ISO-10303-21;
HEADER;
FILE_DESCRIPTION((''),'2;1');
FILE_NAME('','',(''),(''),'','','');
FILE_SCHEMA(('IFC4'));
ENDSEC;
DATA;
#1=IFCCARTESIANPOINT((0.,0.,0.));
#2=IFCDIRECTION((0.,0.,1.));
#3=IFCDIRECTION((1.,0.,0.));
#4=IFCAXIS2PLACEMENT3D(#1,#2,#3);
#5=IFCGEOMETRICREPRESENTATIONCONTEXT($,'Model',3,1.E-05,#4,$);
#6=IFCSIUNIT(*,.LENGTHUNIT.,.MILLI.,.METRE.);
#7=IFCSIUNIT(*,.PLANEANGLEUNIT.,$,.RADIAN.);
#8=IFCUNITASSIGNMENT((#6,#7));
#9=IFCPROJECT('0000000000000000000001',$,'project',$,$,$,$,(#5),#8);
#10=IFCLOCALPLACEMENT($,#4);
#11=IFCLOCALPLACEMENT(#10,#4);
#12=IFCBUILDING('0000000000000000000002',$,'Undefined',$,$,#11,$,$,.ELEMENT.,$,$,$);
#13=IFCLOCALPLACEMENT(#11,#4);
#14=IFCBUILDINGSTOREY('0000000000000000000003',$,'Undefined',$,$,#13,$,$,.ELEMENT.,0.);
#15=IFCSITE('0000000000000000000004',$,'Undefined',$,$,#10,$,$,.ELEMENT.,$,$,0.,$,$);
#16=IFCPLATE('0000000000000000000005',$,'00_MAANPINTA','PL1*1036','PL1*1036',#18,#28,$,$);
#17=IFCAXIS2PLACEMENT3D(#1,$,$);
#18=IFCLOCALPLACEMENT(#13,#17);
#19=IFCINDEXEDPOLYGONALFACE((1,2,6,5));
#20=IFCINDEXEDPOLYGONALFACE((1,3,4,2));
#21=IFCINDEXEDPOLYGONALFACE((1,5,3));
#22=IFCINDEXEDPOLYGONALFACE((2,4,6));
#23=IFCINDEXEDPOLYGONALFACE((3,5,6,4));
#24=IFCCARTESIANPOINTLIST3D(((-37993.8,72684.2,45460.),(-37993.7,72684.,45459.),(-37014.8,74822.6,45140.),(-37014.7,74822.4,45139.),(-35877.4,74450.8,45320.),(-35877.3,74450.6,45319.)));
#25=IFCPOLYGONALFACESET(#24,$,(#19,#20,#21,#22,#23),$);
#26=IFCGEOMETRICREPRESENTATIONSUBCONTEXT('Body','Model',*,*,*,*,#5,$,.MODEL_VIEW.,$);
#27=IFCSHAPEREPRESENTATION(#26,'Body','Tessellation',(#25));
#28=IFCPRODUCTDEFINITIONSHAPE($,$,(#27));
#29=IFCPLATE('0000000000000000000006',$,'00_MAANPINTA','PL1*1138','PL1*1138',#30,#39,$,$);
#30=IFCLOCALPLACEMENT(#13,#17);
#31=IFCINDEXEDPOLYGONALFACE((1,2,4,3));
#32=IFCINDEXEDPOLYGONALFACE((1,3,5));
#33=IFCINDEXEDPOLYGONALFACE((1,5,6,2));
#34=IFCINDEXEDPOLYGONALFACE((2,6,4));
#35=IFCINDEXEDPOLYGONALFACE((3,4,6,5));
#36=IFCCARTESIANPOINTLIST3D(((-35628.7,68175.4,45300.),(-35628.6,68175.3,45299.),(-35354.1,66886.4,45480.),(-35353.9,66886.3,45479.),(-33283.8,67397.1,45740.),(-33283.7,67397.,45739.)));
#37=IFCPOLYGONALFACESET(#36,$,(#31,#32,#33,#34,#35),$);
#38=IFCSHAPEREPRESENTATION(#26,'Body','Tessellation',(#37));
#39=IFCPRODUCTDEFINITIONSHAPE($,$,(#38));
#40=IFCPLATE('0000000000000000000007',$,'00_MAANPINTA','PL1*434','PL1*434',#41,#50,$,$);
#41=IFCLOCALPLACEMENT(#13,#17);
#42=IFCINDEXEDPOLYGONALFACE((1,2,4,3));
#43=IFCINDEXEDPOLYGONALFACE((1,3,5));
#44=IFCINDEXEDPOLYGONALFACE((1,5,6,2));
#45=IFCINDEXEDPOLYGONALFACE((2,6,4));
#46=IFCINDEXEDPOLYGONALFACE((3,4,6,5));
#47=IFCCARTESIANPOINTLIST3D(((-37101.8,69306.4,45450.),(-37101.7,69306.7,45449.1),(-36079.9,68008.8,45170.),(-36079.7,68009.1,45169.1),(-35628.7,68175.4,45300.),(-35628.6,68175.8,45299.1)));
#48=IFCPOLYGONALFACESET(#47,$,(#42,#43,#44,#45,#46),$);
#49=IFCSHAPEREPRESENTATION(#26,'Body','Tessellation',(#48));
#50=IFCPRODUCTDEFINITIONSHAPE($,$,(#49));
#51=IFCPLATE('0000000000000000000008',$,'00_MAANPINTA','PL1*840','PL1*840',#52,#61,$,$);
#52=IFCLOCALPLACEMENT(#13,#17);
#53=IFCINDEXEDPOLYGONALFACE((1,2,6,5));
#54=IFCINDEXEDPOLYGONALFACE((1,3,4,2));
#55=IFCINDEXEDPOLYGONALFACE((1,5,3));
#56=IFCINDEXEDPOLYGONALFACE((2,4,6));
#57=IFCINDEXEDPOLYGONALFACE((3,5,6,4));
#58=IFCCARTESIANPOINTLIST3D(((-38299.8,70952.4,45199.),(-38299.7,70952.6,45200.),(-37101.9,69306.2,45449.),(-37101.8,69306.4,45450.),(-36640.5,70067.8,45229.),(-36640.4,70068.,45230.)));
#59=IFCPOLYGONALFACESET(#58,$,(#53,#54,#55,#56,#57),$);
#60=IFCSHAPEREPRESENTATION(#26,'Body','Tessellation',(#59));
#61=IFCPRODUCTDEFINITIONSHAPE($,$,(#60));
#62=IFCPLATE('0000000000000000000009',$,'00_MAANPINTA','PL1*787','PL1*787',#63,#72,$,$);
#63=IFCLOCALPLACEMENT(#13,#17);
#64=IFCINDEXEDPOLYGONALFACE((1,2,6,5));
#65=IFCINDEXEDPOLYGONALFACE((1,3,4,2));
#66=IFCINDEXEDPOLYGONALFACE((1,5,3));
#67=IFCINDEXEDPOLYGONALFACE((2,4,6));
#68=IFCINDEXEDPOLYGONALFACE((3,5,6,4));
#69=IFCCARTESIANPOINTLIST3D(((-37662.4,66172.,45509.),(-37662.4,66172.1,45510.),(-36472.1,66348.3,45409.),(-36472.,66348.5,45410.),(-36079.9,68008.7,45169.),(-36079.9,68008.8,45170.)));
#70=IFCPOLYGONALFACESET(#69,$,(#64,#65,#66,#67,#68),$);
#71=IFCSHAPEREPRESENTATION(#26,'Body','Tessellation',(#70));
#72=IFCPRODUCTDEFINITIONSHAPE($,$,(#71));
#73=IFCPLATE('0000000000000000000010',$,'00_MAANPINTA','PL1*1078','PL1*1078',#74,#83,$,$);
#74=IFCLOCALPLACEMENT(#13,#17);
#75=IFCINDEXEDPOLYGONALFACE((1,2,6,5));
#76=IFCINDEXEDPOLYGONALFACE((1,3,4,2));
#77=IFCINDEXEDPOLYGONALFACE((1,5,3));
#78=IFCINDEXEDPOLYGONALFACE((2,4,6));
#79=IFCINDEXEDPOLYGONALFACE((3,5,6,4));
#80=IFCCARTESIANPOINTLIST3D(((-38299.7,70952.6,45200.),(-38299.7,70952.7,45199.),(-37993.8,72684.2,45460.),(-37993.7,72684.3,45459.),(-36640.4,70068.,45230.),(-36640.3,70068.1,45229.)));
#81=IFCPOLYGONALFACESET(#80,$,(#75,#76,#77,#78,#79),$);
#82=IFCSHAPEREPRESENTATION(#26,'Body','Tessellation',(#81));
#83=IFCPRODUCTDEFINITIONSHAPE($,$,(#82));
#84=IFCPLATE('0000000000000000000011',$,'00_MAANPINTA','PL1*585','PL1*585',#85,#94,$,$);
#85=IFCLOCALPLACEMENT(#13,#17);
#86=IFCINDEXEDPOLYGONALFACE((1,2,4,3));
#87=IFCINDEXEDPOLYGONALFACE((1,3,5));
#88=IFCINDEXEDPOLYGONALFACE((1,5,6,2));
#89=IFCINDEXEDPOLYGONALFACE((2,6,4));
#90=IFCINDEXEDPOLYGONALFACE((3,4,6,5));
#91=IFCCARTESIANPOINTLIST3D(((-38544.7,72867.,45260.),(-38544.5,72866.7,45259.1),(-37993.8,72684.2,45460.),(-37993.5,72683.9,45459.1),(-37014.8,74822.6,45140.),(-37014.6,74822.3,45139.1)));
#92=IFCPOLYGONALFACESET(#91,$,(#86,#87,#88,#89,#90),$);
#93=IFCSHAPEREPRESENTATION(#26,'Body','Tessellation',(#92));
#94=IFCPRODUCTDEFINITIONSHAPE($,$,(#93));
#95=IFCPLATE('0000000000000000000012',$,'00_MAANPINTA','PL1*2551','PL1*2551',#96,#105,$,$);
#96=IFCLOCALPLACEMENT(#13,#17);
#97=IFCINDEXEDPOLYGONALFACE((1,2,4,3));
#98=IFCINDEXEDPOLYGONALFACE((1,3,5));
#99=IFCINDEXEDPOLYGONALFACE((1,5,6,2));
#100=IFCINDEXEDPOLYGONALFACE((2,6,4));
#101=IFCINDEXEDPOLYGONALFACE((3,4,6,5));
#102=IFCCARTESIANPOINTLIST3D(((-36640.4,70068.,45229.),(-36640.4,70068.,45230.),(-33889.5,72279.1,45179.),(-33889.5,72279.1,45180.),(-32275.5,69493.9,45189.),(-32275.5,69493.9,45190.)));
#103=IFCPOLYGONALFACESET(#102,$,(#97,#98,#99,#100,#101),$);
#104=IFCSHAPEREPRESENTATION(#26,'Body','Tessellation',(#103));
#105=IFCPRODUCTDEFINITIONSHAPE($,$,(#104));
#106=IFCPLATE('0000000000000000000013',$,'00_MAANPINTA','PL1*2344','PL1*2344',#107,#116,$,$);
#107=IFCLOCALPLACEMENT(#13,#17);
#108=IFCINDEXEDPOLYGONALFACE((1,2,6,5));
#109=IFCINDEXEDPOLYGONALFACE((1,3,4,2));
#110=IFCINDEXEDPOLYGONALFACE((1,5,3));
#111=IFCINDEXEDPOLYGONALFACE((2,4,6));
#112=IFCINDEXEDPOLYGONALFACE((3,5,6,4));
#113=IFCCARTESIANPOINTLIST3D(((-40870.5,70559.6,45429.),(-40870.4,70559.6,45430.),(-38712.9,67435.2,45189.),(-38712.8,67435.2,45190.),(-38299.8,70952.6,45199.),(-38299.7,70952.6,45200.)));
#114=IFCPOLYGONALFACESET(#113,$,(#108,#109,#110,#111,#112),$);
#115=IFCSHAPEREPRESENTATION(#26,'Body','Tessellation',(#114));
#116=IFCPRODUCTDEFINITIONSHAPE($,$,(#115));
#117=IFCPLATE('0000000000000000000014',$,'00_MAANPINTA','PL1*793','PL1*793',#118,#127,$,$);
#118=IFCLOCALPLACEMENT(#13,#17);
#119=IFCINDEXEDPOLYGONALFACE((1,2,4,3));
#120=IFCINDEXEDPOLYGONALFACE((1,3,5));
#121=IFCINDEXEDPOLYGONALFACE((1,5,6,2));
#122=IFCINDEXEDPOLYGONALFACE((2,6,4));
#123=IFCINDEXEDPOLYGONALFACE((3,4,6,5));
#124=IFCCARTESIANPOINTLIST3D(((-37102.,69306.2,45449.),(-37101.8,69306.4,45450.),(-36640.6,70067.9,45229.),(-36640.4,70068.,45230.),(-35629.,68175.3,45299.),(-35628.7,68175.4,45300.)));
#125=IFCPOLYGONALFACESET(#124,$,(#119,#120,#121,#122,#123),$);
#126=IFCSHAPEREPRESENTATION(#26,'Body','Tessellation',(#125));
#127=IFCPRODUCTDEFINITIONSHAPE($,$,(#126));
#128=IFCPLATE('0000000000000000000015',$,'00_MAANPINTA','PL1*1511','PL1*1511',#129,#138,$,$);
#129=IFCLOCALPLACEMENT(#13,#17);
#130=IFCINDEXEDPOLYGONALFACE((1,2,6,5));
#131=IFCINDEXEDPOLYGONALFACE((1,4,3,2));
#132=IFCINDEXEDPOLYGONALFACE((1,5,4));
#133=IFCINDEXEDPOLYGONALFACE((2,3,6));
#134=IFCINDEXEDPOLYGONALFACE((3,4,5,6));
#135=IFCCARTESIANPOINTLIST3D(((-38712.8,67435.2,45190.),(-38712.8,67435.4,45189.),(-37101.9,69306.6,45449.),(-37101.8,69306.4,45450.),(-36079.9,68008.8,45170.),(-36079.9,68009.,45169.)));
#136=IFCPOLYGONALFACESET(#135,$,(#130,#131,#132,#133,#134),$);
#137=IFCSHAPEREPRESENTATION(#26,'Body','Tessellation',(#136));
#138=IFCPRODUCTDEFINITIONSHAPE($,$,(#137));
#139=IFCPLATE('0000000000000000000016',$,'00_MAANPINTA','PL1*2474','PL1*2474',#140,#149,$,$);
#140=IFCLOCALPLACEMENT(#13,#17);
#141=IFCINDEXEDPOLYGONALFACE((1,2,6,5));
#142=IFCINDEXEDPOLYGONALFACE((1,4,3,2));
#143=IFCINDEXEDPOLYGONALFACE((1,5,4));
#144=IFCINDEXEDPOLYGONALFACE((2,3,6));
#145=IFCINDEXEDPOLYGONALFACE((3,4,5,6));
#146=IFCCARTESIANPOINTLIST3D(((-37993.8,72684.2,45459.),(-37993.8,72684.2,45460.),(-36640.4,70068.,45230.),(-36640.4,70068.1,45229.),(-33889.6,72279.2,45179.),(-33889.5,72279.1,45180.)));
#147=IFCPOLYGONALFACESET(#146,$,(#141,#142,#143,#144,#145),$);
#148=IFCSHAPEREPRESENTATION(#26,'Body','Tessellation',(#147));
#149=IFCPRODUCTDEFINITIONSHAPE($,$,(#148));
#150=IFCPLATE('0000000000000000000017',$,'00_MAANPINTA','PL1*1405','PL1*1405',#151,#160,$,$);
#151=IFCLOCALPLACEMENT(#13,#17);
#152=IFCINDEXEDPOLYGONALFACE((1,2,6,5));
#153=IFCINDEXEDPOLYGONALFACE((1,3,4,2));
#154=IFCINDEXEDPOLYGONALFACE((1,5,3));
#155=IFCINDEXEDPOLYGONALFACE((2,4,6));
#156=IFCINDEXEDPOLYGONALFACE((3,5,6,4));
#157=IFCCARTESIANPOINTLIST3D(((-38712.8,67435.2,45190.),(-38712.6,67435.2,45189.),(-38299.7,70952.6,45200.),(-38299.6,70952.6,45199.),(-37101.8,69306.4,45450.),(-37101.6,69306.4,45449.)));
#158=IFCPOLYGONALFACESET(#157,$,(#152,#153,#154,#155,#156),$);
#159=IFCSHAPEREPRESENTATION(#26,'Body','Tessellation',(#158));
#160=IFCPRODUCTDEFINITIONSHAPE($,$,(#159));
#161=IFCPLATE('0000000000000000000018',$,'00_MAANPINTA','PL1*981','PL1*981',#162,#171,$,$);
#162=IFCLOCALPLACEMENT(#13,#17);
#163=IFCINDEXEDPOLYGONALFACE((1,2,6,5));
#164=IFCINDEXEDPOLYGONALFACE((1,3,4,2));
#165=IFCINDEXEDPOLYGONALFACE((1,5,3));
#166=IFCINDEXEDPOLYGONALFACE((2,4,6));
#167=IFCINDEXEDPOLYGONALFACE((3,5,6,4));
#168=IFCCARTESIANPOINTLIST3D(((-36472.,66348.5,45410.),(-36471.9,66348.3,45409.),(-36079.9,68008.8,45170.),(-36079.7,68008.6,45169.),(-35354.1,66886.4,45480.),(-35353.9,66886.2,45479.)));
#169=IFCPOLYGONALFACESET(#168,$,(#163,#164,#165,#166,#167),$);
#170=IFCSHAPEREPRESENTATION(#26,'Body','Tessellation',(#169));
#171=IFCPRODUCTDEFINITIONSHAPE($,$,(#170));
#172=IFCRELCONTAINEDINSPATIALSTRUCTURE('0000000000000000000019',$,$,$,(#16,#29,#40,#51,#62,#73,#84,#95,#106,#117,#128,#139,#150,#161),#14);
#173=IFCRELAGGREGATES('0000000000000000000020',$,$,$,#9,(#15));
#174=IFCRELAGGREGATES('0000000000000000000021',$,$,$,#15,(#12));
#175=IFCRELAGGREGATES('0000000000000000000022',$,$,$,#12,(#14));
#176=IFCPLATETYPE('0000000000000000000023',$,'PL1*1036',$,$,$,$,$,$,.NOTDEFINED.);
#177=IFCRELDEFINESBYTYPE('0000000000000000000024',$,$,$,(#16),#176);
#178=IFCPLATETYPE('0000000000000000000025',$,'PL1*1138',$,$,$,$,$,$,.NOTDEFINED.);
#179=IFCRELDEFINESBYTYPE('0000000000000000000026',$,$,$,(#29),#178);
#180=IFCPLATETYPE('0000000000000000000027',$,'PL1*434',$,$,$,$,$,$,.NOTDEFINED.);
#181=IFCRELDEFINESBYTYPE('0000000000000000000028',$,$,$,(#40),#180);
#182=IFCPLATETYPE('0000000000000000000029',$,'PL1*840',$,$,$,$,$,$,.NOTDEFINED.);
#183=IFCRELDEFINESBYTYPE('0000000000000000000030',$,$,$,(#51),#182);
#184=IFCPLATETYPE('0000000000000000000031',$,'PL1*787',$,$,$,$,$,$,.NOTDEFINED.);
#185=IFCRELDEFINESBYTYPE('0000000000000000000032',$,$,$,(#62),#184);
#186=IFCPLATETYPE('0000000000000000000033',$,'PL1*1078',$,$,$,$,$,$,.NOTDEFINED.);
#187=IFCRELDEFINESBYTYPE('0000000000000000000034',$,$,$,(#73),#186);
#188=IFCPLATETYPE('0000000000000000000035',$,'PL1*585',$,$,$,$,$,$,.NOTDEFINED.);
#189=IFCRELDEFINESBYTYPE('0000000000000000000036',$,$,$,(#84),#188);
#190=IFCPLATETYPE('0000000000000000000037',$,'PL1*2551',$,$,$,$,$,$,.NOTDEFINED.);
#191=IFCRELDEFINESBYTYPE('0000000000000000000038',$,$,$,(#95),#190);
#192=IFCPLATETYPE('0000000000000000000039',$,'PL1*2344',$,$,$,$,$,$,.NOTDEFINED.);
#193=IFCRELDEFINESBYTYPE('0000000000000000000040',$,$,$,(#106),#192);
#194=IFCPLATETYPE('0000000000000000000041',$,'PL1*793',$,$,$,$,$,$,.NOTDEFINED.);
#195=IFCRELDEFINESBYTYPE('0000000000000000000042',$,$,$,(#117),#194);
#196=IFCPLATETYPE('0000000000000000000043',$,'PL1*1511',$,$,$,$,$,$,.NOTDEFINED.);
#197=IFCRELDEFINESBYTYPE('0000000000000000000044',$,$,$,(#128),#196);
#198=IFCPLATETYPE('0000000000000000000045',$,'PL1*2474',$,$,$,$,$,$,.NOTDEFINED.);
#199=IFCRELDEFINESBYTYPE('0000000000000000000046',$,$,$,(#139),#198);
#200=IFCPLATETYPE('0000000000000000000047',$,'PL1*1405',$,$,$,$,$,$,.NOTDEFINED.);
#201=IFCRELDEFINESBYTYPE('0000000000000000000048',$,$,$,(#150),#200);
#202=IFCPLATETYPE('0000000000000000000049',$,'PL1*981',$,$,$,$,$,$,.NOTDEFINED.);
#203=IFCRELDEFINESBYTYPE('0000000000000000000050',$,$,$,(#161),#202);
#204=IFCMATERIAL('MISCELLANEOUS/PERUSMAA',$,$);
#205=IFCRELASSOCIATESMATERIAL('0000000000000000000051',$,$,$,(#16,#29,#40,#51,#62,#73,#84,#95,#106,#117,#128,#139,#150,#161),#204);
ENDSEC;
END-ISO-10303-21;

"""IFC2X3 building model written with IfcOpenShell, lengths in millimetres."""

from ifc_helpers import new_model, si_unit, frame, origin_with_axes, place, context, subcontext, project, spatial, polyline, outline, extrude, material, type_object, element, save


model = new_model("IFC2X3")

# Units and contexts
model_context = context("Model", 3, precision=1e-05, world=origin_with_axes())
body_context = subcontext(model_context, "Body", "Model", "MODEL_VIEW")
ifc_project = project(units=[si_unit("LENGTHUNIT", "METRE", prefix="MILLI"), si_unit("PLANEANGLEUNIT", "RADIAN")], contexts=[model_context])

# Site, building, storey
site_placement = place(None, origin_with_axes())
site = spatial("IfcSite", under=ifc_project, at=site_placement, Name="Undefined", CompositionType="ELEMENT", RefElevation=0.0)
building_placement = place(site_placement, origin_with_axes())
building = spatial("IfcBuilding", under=site, at=building_placement, Name="Undefined", CompositionType="ELEMENT")
storey_placement = place(building_placement, origin_with_axes())
storey = spatial("IfcBuildingStorey", under=building, at=storey_placement, Name="Undefined", CompositionType="ELEMENT", Elevation=0.0)

# Plates
ifc_material = material(Name="MISCELLANEOUS/PERUSMAA")
plate_type_1 = type_object("IfcPlateType", Name="PL1*1036", PredefinedType="NOTDEFINED")
plate_1_placement = place(storey_placement, frame((-37993.7, 72684.1, 45459.5), z_axis=(0.092969, -0.188849, -0.977595), x_axis=(0.412439, 0.900954, -0.134821)))
element("IfcPlate", 1, at=plate_1_placement, inside=storey, type_object=plate_type_1, material=ifc_material, Name="00_MAANPINTA", Description="PL1*1036", ObjectType="PL1*1036", context=body_context, shape_type="SweptSolid", body=[
    extrude(outline(polyline([(0.0, 0.0), (2373.5, 0.0), (2483.4, 1205.2), (0.0, 0.0)])), frame((0.0, 0.0, -0.5), z_axis=(0.0, 0.0, 1.0), x_axis=(1.0, 0.0, 0.0)), (0.0, 0.0, 1.0), 1.0),
])
plate_type_2 = type_object("IfcPlateType", Name="PL1*1138", PredefinedType="NOTDEFINED")
plate_2_placement = place(storey_placement, frame((-35628.7, 68175.4, 45299.5), z_axis=(0.149478, -0.105435, -0.983128), x_axis=(0.934388, -0.310129, 0.175327)))
element("IfcPlate", 2, at=plate_2_placement, inside=storey, type_object=plate_type_2, material=ifc_material, Name="00_MAANPINTA", Description="PL1*1138", ObjectType="PL1*1138", context=body_context, shape_type="SweptSolid", body=[
    extrude(outline(polyline([(0.0, 0.0), (2509.6, 0.0), (688.0, 1138.5), (0.0, 0.0)])), frame((0.0, 0.0, -0.5), z_axis=(0.0, 0.0, 1.0), x_axis=(1.0, 0.0, 0.0)), (0.0, 0.0, 1.0), 1.0),
])
plate_type_3 = type_object("IfcPlateType", Name="PL1*434", PredefinedType="NOTDEFINED")
plate_3_placement = place(storey_placement, frame((-37101.7, 69306.5, 45449.5), z_axis=(0.15099, 0.320689, -0.935073), x_axis=(0.79062, -0.606991, -0.080507)))
element("IfcPlate", 3, at=plate_3_placement, inside=storey, type_object=plate_type_3, material=ifc_material, Name="00_MAANPINTA", Description="PL1*434", ObjectType="PL1*434", context=body_context, shape_type="SweptSolid", body=[
    extrude(outline(polyline([(0.0, 0.0), (1863.2, 0.0), (1618.1, 433.8), (0.0, 0.0)])), frame((0.0, 0.0, -0.5), z_axis=(0.0, 0.0, 1.0), x_axis=(1.0, 0.0, 0.0)), (0.0, 0.0, 1.0), 1.0),
])
plate_type_4 = type_object("IfcPlateType", Name="PL1*840", PredefinedType="NOTDEFINED")
plate_4_placement = place(storey_placement, frame((-38299.8, 70952.5, 45199.5), z_axis=(-0.099687, -0.219913, -0.970413), x_axis=(0.882333, -0.470355, 0.015952)))
element("IfcPlate", 4, at=plate_4_placement, inside=storey, type_object=plate_type_4, material=ifc_material, Name="00_MAANPINTA", Description="PL1*840", ObjectType="PL1*840", context=body_context, shape_type="SweptSolid", body=[
    extrude(outline(polyline([(0.0, 0.0), (1880.7, 0.0), (1835.3, 916.2), (0.0, 0.0)])), frame((0.0, 0.0, -0.5), z_axis=(0.0, 0.0, 1.0), x_axis=(1.0, 0.0, 0.0)), (0.0, 0.0, 1.0), 1.0),
])
plate_type_5 = type_object("IfcPlateType", Name="PL1*787", PredefinedType="NOTDEFINED")
plate_5_placement = place(storey_placement, frame((-36079.9, 68008.7, 45169.5), z_axis=(-0.064195, -0.127899, -0.989707), x_axis=(-0.227614, -0.963735, 0.139307)))
element("IfcPlate", 5, at=plate_5_placement, inside=storey, type_object=plate_type_5, material=ifc_material, Name="00_MAANPINTA", Description="PL1*787", ObjectType="PL1*787", context=body_context, shape_type="SweptSolid", body=[
    extrude(outline(polyline([(0.0, 0.0), (1722.8, 0.0), (2177.7, 1118.5), (0.0, 0.0)])), frame((0.0, 0.0, -0.5), z_axis=(0.0, 0.0, 1.0), x_axis=(1.0, 0.0, 0.0)), (0.0, 0.0, 1.0), 1.0),
])
plate_type_6 = type_object("IfcPlateType", Name="PL1*1078", PredefinedType="NOTDEFINED")
plate_6_placement = place(storey_placement, frame((-36640.3, 70068.1, 45229.5), z_axis=(0.088528, 0.132588, -0.98721), x_axis=(-0.882333, 0.470355, -0.015952)))
element("IfcPlate", 6, at=plate_6_placement, inside=storey, type_object=plate_type_6, material=ifc_material, Name="00_MAANPINTA", Description="PL1*1078", ObjectType="PL1*1078", context=body_context, shape_type="SweptSolid", body=[
    extrude(outline(polyline([(0.0, 0.0), (1880.7, 0.0), (2421.0, 1693.4), (0.0, 0.0)])), frame((0.0, 0.0, -0.5), z_axis=(0.0, 0.0, 1.0), x_axis=(1.0, 0.0, 0.0)), (0.0, 0.0, 1.0), 1.0),
])
plate_type_7 = type_object("IfcPlateType", Name="PL1*585", PredefinedType="NOTDEFINED")
plate_7_placement = place(storey_placement, frame((-37993.6, 72684.0, 45459.5), z_axis=(0.25375, -0.255755, -0.932845), x_axis=(-0.897349, 0.297766, -0.325731)))
element("IfcPlate", 7, at=plate_7_placement, inside=storey, type_object=plate_type_7, material=ifc_material, Name="00_MAANPINTA", Description="PL1*585", ObjectType="PL1*585", context=body_context, shape_type="SweptSolid", body=[
    extrude(outline(polyline([(0.0, 0.0), (614.0, 0.0), (-137.5, 2369.5), (0.0, 0.0)])), frame((0.0, 0.0, -0.5), z_axis=(0.0, 0.0, 1.0), x_axis=(1.0, 0.0, 0.0)), (0.0, 0.0, 1.0), 1.0),
])
plate_type_8 = type_object("IfcPlateType", Name="PL1*2551", PredefinedType="NOTDEFINED")
plate_8_placement = place(storey_placement, frame((-33889.5, 72279.1, 45179.5), z_axis=(-0.01043, -0.009634, -0.999899), x_axis=(0.501386, -0.865218, 0.003106)))
element("IfcPlate", 8, at=plate_8_placement, inside=storey, type_object=plate_type_8, material=ifc_material, Name="00_MAANPINTA", Description="PL1*2551", ObjectType="PL1*2551", context=body_context, shape_type="SweptSolid", body=[
    extrude(outline(polyline([(0.0, 0.0), (3219.1, 0.0), (534.0, 3489.1), (0.0, 0.0)])), frame((0.0, 0.0, -0.5), z_axis=(0.0, 0.0, 1.0), x_axis=(1.0, 0.0, 0.0)), (0.0, 0.0, 1.0), 1.0),
])
plate_type_9 = type_object("IfcPlateType", Name="PL1*2344", PredefinedType="NOTDEFINED")
plate_9_placement = place(storey_placement, frame((-38712.8, 67435.2, 45189.5), z_axis=(-0.091161, 0.013536, -0.995744), x_axis=(-0.567103, 0.821227, 0.063082)))
element("IfcPlate", 9, at=plate_9_placement, inside=storey, type_object=plate_type_9, material=ifc_material, Name="00_MAANPINTA", Description="PL1*2344", ObjectType="PL1*2344", context=body_context, shape_type="SweptSolid", body=[
    extrude(outline(polyline([(0.0, 0.0), (3804.5, 0.0), (2655.0, 2343.9), (0.0, 0.0)])), frame((0.0, 0.0, -0.5), z_axis=(0.0, 0.0, 1.0), x_axis=(1.0, 0.0, 0.0)), (0.0, 0.0, 1.0), 1.0),
])
plate_type_10 = type_object("IfcPlateType", Name="PL1*793", PredefinedType="NOTDEFINED")
plate_10_placement = place(storey_placement, frame((-35628.8, 68175.4, 45299.5), z_axis=(-0.213233, -0.149689, -0.965466), x_axis=(-0.79062, 0.606991, 0.080507)))
element("IfcPlate", 10, at=plate_10_placement, inside=storey, type_object=plate_type_10, material=ifc_material, Name="00_MAANPINTA", Description="PL1*793", ObjectType="PL1*793", context=body_context, shape_type="SweptSolid", body=[
    extrude(outline(polyline([(0.0, 0.0), (1863.2, 0.0), (1943.0, 913.8), (0.0, 0.0)])), frame((0.0, 0.0, -0.5), z_axis=(0.0, 0.0, 1.0), x_axis=(1.0, 0.0, 0.0)), (0.0, 0.0, 1.0), 1.0),
])
plate_type_11 = type_object("IfcPlateType", Name="PL1*1511", PredefinedType="NOTDEFINED")
plate_11_placement = place(storey_placement, frame((-37101.8, 69306.5, 45449.5), z_axis=(-0.04583, 0.176088, -0.983307), x_axis=(0.610018, -0.77456, -0.167138)))
element("IfcPlate", 11, at=plate_11_placement, inside=storey, type_object=plate_type_11, material=ifc_material, Name="00_MAANPINTA", Description="PL1*1511", ObjectType="PL1*1511", context=body_context, shape_type="SweptSolid", body=[
    extrude(outline(polyline([(0.0, 0.0), (1675.3, 0.0), (510.1, 2429.8), (0.0, 0.0)])), frame((0.0, 0.0, -0.5), z_axis=(0.0, 0.0, 1.0), x_axis=(1.0, 0.0, 0.0)), (0.0, 0.0, 1.0), 1.0),
])
plate_type_12 = type_object("IfcPlateType", Name="PL1*2474", PredefinedType="NOTDEFINED")
plate_12_placement = place(storey_placement, frame((-36640.4, 70068.0, 45229.5), z_axis=(-0.06253, 0.05526, -0.996512), x_axis=(-0.458085, 0.885493, 0.077848)))
element("IfcPlate", 12, at=plate_12_placement, inside=storey, type_object=plate_type_12, material=ifc_material, Name="00_MAANPINTA", Description="PL1*2474", ObjectType="PL1*2474", context=body_context, shape_type="SweptSolid", body=[
    extrude(outline(polyline([(0.0, 0.0), (2954.5, 0.0), (693.9, 3460.8), (0.0, 0.0)])), frame((0.0, 0.0, -0.5), z_axis=(0.0, 0.0, 1.0), x_axis=(1.0, 0.0, 0.0)), (0.0, 0.0, 1.0), 1.0),
])
plate_type_13 = type_object("IfcPlateType", Name="PL1*1405", PredefinedType="NOTDEFINED")
plate_13_placement = place(storey_placement, frame((-38299.7, 70952.6, 45199.5), z_axis=(0.180038, -0.018346, -0.983489), x_axis=(0.584006, -0.802547, 0.121879)))
element("IfcPlate", 13, at=plate_13_placement, inside=storey, type_object=plate_type_13, material=ifc_material, Name="00_MAANPINTA", Description="PL1*1405", ObjectType="PL1*1405", context=body_context, shape_type="SweptSolid", body=[
    extrude(outline(polyline([(0.0, 0.0), (2051.2, 0.0), (2580.4, 2425.7), (0.0, 0.0)])), frame((0.0, 0.0, -0.5), z_axis=(0.0, 0.0, 1.0), x_axis=(1.0, 0.0, 0.0)), (0.0, 0.0, 1.0), 1.0),
])
plate_type_14 = type_object("IfcPlateType", Name="PL1*981", PredefinedType="NOTDEFINED")
plate_14_placement = place(storey_placement, frame((-36079.8, 68008.7, 45169.5), z_axis=(0.145214, -0.175057, -0.97379), x_axis=(0.528979, -0.818006, 0.225935)))
element("IfcPlate", 14, at=plate_14_placement, inside=storey, type_object=plate_type_14, material=ifc_material, Name="00_MAANPINTA", Description="PL1*981", ObjectType="PL1*981", context=body_context, shape_type="SweptSolid", body=[
    extrude(outline(polyline([(0.0, 0.0), (1372.1, 0.0), (1205.0, 1231.3), (0.0, 0.0)])), frame((0.0, 0.0, -0.5), z_axis=(0.0, 0.0, 1.0), x_axis=(1.0, 0.0, 0.0)), (0.0, 0.0, 1.0), 1.0),
])

save(model, "model.ifc")
